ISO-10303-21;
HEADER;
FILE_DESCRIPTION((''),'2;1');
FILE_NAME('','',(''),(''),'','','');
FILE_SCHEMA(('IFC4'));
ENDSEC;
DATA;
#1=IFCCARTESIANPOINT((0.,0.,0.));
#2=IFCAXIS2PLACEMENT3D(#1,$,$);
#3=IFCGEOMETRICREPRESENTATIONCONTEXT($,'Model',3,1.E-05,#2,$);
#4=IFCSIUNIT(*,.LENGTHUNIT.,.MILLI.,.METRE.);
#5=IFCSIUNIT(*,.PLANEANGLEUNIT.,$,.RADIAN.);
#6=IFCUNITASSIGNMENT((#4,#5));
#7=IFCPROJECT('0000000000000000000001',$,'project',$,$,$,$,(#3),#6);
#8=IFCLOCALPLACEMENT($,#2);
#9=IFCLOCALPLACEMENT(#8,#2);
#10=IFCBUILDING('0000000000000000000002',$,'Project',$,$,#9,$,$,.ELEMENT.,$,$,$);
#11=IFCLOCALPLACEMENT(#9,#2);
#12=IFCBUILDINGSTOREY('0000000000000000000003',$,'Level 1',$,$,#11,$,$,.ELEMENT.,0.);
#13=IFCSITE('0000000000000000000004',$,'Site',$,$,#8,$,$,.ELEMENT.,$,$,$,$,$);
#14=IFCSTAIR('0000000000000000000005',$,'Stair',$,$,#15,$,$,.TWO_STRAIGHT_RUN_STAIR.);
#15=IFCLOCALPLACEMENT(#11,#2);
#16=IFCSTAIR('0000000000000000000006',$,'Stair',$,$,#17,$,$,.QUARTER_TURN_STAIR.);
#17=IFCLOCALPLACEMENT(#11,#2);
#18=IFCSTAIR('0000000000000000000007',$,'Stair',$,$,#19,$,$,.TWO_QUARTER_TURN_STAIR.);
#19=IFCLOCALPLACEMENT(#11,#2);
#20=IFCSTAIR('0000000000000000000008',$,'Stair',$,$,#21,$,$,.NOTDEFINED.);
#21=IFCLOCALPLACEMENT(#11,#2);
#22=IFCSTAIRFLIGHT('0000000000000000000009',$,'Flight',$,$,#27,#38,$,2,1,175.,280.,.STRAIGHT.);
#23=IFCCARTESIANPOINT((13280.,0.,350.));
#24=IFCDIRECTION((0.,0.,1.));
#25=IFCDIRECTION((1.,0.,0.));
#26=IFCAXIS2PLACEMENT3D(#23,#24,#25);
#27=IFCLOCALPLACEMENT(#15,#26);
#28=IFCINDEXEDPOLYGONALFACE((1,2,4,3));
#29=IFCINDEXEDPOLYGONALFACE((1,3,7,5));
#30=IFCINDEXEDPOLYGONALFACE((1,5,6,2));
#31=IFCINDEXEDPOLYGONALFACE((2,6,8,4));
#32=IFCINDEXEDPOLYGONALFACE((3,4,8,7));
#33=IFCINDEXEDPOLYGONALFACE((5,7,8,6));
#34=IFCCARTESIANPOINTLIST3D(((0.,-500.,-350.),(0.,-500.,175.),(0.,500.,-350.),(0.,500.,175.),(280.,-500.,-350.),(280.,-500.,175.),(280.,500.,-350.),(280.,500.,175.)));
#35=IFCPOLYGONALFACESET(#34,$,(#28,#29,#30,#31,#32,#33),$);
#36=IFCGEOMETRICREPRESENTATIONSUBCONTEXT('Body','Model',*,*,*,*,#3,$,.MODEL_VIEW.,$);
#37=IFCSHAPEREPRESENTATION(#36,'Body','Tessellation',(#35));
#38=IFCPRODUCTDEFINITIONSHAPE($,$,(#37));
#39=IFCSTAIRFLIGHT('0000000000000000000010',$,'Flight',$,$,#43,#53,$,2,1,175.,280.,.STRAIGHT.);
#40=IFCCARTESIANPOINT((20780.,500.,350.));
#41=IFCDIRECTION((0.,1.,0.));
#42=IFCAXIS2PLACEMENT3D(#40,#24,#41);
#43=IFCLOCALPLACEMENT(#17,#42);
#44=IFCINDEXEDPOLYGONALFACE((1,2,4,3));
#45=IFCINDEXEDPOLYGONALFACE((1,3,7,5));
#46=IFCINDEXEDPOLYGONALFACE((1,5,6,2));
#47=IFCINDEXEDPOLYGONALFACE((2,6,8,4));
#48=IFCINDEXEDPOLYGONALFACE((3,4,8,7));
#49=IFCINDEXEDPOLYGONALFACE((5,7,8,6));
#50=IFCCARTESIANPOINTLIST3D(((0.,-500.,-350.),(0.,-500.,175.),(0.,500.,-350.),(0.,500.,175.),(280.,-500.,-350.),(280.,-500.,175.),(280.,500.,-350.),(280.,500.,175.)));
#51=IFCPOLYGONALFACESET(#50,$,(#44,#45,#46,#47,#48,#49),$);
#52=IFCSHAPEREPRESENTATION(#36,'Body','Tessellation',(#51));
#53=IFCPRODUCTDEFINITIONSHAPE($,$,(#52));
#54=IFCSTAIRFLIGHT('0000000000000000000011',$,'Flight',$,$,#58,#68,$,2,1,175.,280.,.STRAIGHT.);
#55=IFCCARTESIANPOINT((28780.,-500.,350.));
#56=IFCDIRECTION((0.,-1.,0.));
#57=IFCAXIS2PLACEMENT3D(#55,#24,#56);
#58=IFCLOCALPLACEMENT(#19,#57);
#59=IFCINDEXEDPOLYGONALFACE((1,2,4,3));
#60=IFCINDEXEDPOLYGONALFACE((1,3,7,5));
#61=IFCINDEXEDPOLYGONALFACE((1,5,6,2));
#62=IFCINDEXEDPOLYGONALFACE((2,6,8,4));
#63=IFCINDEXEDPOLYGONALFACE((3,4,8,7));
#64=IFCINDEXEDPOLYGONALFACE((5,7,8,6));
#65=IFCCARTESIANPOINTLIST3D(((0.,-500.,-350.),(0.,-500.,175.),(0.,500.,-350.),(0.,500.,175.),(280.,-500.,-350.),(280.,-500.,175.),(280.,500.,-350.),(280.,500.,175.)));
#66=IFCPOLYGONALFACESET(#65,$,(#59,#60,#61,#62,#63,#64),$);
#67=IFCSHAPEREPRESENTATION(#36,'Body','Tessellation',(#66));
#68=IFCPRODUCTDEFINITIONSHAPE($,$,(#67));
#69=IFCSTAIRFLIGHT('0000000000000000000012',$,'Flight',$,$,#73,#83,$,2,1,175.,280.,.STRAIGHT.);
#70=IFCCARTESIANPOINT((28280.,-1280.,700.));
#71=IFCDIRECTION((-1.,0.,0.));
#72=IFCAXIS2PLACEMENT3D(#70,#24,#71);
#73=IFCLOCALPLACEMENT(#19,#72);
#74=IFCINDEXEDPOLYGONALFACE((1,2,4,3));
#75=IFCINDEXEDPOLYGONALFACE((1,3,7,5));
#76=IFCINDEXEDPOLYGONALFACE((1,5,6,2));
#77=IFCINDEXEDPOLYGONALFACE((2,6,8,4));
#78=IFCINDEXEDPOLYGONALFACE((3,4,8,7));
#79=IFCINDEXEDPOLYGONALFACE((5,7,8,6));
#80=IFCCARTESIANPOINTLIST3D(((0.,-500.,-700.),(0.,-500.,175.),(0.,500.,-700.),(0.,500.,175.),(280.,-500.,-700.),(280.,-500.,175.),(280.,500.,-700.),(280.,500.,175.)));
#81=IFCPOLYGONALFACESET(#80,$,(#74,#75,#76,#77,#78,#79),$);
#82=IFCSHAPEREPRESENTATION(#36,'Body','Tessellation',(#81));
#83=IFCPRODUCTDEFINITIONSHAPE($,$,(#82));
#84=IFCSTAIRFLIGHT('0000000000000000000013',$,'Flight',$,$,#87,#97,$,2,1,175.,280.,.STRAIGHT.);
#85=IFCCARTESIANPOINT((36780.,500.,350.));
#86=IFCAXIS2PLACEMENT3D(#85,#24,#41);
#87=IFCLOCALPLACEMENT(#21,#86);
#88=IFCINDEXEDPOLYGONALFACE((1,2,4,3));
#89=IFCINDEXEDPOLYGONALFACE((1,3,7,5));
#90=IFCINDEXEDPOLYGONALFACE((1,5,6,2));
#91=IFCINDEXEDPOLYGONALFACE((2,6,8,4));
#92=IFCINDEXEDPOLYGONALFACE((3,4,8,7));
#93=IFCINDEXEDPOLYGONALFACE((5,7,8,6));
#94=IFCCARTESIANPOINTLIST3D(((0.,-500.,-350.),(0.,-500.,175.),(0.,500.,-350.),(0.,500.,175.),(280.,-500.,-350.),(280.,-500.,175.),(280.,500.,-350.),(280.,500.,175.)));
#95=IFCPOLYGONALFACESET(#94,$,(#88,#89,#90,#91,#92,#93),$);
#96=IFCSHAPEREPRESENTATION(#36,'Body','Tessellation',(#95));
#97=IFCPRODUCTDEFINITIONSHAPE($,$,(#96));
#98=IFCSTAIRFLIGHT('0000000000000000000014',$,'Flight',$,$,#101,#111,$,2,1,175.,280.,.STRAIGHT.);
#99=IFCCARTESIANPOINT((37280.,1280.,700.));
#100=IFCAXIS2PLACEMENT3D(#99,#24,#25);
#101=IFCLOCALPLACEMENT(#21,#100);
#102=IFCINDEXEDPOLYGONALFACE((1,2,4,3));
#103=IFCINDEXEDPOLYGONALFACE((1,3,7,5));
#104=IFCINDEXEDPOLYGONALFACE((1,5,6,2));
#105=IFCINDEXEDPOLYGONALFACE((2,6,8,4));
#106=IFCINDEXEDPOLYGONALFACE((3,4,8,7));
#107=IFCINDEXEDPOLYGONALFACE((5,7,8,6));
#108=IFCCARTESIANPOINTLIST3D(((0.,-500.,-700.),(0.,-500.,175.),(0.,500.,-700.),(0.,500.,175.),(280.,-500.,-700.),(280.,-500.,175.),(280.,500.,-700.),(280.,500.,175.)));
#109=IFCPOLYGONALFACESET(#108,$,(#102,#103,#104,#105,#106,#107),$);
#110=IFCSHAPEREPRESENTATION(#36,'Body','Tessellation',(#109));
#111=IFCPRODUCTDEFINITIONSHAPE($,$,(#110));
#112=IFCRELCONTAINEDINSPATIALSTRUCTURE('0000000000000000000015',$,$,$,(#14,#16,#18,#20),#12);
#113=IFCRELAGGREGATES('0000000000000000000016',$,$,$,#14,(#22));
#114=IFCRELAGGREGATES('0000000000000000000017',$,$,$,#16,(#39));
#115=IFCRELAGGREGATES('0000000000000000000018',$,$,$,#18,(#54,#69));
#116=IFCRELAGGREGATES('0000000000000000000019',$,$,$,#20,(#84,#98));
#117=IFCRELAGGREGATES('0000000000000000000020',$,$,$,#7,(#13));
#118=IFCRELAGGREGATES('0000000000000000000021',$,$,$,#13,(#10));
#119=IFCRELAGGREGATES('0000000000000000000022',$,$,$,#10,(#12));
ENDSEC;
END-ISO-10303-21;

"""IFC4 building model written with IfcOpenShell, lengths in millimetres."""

from ifc_helpers import new_model, si_unit, frame, frame_2d, origin, place, context, subcontext, project, spatial, rectangle, extrude, element, aggregate, save


model = new_model("IFC4")

# Units and contexts
model_context = context("Model", 3, precision=1e-05, world=origin())
body_context = subcontext(model_context, "Body", "Model", "MODEL_VIEW")
ifc_project = project(units=[si_unit("LENGTHUNIT", "METRE", prefix="MILLI"), si_unit("PLANEANGLEUNIT", "RADIAN")], contexts=[model_context])

# Site, building, storey
site_placement = place(None, origin())
site = spatial("IfcSite", under=ifc_project, at=site_placement, Name="Site", CompositionType="ELEMENT")
building_placement = place(site_placement, origin())
building = spatial("IfcBuilding", under=site, at=building_placement, Name="Project", CompositionType="ELEMENT")
storey_placement = place(building_placement, origin())
storey = spatial("IfcBuildingStorey", under=building, at=storey_placement, Name="Level 1", CompositionType="ELEMENT", Elevation=0.0)

# Stairs
stair_1_placement = place(storey_placement, origin())
stair_1 = element("IfcStair", 1, at=stair_1_placement, inside=storey, Name="Stair", PredefinedType="TWO_STRAIGHT_RUN_STAIR")
stair_2_placement = place(storey_placement, origin())
stair_2 = element("IfcStair", 2, at=stair_2_placement, inside=storey, Name="Stair", PredefinedType="QUARTER_TURN_STAIR")

# Stairs
stair_3_placement = place(storey_placement, origin())
stair_3 = element("IfcStair", 3, at=stair_3_placement, inside=storey, Name="Stair", PredefinedType="TWO_QUARTER_TURN_STAIR")
stair_4_placement = place(storey_placement, origin())
stair_4 = element("IfcStair", 4, at=stair_4_placement, inside=storey, Name="Stair", PredefinedType="NOTDEFINED")

# Stair flights
stair_flight_1_placement = place(stair_1_placement, frame((13280.0, 0.0, 350.0), z_axis=(0.0, 0.0, 1.0), x_axis=(1.0, 0.0, 0.0)))
stair_flight_1 = element("IfcStairFlight", 5, at=stair_flight_1_placement, Name="Flight", NumberOfRisers=2, NumberOfTreads=1, PredefinedType="STRAIGHT", RiserHeight=175.0, TreadLength=280.0, context=body_context, shape_type="SweptSolid", body=[
    extrude(rectangle(XDim=280.0, YDim=1000.0, at=frame_2d((140.0, 0.0))), frame((0.0, 0.0, -350.0)), (0.0, 0.0, 1.0), 525.0),
])
aggregate(stair_1, [stair_flight_1])
stair_flight_2_placement = place(stair_2_placement, frame((20780.0, 500.0, 350.0), z_axis=(0.0, 0.0, 1.0), x_axis=(0.0, 1.0, 0.0)))
stair_flight_2 = element("IfcStairFlight", 6, at=stair_flight_2_placement, Name="Flight", NumberOfRisers=2, NumberOfTreads=1, PredefinedType="STRAIGHT", RiserHeight=175.0, TreadLength=280.0, context=body_context, shape_type="SweptSolid", body=[
    extrude(rectangle(XDim=280.0, YDim=1000.0, at=frame_2d((140.0, 0.0))), frame((0.0, 0.0, -350.0)), (0.0, 0.0, 1.0), 525.0),
])
aggregate(stair_2, [stair_flight_2])
stair_flight_3_placement = place(stair_3_placement, frame((28780.0, -500.0, 350.0), z_axis=(0.0, 0.0, 1.0), x_axis=(0.0, -1.0, 0.0)))
stair_flight_3 = element("IfcStairFlight", 7, at=stair_flight_3_placement, Name="Flight", NumberOfRisers=2, NumberOfTreads=1, PredefinedType="STRAIGHT", RiserHeight=175.0, TreadLength=280.0, context=body_context, shape_type="SweptSolid", body=[
    extrude(rectangle(XDim=280.0, YDim=1000.0, at=frame_2d((140.0, 0.0))), frame((0.0, 0.0, -350.0)), (0.0, 0.0, 1.0), 525.0),
])
stair_flight_4_placement = place(stair_3_placement, frame((28280.0, -1280.0, 700.0), z_axis=(0.0, 0.0, 1.0), x_axis=(-1.0, 0.0, 0.0)))
stair_flight_4 = element("IfcStairFlight", 8, at=stair_flight_4_placement, Name="Flight", NumberOfRisers=2, NumberOfTreads=1, PredefinedType="STRAIGHT", RiserHeight=175.0, TreadLength=280.0, context=body_context, shape_type="SweptSolid", body=[
    extrude(rectangle(XDim=280.0, YDim=1000.0, at=frame_2d((140.0, 0.0))), frame((0.0, 0.0, -700.0)), (0.0, 0.0, 1.0), 875.0),
])
aggregate(stair_3, [stair_flight_3, stair_flight_4])
stair_flight_5_placement = place(stair_4_placement, frame((36780.0, 500.0, 350.0), z_axis=(0.0, 0.0, 1.0), x_axis=(0.0, 1.0, 0.0)))
stair_flight_5 = element("IfcStairFlight", 9, at=stair_flight_5_placement, Name="Flight", NumberOfRisers=2, NumberOfTreads=1, PredefinedType="STRAIGHT", RiserHeight=175.0, TreadLength=280.0, context=body_context, shape_type="SweptSolid", body=[
    extrude(rectangle(XDim=280.0, YDim=1000.0, at=frame_2d((140.0, 0.0))), frame((0.0, 0.0, -350.0)), (0.0, 0.0, 1.0), 525.0),
])
stair_flight_6_placement = place(stair_4_placement, frame((37280.0, 1280.0, 700.0), z_axis=(0.0, 0.0, 1.0), x_axis=(1.0, 0.0, 0.0)))
stair_flight_6 = element("IfcStairFlight", 10, at=stair_flight_6_placement, Name="Flight", NumberOfRisers=2, NumberOfTreads=1, PredefinedType="STRAIGHT", RiserHeight=175.0, TreadLength=280.0, context=body_context, shape_type="SweptSolid", body=[
    extrude(rectangle(XDim=280.0, YDim=1000.0, at=frame_2d((140.0, 0.0))), frame((0.0, 0.0, -700.0)), (0.0, 0.0, 1.0), 875.0),
])
aggregate(stair_4, [stair_flight_5, stair_flight_6])

save(model, "model.ifc")
